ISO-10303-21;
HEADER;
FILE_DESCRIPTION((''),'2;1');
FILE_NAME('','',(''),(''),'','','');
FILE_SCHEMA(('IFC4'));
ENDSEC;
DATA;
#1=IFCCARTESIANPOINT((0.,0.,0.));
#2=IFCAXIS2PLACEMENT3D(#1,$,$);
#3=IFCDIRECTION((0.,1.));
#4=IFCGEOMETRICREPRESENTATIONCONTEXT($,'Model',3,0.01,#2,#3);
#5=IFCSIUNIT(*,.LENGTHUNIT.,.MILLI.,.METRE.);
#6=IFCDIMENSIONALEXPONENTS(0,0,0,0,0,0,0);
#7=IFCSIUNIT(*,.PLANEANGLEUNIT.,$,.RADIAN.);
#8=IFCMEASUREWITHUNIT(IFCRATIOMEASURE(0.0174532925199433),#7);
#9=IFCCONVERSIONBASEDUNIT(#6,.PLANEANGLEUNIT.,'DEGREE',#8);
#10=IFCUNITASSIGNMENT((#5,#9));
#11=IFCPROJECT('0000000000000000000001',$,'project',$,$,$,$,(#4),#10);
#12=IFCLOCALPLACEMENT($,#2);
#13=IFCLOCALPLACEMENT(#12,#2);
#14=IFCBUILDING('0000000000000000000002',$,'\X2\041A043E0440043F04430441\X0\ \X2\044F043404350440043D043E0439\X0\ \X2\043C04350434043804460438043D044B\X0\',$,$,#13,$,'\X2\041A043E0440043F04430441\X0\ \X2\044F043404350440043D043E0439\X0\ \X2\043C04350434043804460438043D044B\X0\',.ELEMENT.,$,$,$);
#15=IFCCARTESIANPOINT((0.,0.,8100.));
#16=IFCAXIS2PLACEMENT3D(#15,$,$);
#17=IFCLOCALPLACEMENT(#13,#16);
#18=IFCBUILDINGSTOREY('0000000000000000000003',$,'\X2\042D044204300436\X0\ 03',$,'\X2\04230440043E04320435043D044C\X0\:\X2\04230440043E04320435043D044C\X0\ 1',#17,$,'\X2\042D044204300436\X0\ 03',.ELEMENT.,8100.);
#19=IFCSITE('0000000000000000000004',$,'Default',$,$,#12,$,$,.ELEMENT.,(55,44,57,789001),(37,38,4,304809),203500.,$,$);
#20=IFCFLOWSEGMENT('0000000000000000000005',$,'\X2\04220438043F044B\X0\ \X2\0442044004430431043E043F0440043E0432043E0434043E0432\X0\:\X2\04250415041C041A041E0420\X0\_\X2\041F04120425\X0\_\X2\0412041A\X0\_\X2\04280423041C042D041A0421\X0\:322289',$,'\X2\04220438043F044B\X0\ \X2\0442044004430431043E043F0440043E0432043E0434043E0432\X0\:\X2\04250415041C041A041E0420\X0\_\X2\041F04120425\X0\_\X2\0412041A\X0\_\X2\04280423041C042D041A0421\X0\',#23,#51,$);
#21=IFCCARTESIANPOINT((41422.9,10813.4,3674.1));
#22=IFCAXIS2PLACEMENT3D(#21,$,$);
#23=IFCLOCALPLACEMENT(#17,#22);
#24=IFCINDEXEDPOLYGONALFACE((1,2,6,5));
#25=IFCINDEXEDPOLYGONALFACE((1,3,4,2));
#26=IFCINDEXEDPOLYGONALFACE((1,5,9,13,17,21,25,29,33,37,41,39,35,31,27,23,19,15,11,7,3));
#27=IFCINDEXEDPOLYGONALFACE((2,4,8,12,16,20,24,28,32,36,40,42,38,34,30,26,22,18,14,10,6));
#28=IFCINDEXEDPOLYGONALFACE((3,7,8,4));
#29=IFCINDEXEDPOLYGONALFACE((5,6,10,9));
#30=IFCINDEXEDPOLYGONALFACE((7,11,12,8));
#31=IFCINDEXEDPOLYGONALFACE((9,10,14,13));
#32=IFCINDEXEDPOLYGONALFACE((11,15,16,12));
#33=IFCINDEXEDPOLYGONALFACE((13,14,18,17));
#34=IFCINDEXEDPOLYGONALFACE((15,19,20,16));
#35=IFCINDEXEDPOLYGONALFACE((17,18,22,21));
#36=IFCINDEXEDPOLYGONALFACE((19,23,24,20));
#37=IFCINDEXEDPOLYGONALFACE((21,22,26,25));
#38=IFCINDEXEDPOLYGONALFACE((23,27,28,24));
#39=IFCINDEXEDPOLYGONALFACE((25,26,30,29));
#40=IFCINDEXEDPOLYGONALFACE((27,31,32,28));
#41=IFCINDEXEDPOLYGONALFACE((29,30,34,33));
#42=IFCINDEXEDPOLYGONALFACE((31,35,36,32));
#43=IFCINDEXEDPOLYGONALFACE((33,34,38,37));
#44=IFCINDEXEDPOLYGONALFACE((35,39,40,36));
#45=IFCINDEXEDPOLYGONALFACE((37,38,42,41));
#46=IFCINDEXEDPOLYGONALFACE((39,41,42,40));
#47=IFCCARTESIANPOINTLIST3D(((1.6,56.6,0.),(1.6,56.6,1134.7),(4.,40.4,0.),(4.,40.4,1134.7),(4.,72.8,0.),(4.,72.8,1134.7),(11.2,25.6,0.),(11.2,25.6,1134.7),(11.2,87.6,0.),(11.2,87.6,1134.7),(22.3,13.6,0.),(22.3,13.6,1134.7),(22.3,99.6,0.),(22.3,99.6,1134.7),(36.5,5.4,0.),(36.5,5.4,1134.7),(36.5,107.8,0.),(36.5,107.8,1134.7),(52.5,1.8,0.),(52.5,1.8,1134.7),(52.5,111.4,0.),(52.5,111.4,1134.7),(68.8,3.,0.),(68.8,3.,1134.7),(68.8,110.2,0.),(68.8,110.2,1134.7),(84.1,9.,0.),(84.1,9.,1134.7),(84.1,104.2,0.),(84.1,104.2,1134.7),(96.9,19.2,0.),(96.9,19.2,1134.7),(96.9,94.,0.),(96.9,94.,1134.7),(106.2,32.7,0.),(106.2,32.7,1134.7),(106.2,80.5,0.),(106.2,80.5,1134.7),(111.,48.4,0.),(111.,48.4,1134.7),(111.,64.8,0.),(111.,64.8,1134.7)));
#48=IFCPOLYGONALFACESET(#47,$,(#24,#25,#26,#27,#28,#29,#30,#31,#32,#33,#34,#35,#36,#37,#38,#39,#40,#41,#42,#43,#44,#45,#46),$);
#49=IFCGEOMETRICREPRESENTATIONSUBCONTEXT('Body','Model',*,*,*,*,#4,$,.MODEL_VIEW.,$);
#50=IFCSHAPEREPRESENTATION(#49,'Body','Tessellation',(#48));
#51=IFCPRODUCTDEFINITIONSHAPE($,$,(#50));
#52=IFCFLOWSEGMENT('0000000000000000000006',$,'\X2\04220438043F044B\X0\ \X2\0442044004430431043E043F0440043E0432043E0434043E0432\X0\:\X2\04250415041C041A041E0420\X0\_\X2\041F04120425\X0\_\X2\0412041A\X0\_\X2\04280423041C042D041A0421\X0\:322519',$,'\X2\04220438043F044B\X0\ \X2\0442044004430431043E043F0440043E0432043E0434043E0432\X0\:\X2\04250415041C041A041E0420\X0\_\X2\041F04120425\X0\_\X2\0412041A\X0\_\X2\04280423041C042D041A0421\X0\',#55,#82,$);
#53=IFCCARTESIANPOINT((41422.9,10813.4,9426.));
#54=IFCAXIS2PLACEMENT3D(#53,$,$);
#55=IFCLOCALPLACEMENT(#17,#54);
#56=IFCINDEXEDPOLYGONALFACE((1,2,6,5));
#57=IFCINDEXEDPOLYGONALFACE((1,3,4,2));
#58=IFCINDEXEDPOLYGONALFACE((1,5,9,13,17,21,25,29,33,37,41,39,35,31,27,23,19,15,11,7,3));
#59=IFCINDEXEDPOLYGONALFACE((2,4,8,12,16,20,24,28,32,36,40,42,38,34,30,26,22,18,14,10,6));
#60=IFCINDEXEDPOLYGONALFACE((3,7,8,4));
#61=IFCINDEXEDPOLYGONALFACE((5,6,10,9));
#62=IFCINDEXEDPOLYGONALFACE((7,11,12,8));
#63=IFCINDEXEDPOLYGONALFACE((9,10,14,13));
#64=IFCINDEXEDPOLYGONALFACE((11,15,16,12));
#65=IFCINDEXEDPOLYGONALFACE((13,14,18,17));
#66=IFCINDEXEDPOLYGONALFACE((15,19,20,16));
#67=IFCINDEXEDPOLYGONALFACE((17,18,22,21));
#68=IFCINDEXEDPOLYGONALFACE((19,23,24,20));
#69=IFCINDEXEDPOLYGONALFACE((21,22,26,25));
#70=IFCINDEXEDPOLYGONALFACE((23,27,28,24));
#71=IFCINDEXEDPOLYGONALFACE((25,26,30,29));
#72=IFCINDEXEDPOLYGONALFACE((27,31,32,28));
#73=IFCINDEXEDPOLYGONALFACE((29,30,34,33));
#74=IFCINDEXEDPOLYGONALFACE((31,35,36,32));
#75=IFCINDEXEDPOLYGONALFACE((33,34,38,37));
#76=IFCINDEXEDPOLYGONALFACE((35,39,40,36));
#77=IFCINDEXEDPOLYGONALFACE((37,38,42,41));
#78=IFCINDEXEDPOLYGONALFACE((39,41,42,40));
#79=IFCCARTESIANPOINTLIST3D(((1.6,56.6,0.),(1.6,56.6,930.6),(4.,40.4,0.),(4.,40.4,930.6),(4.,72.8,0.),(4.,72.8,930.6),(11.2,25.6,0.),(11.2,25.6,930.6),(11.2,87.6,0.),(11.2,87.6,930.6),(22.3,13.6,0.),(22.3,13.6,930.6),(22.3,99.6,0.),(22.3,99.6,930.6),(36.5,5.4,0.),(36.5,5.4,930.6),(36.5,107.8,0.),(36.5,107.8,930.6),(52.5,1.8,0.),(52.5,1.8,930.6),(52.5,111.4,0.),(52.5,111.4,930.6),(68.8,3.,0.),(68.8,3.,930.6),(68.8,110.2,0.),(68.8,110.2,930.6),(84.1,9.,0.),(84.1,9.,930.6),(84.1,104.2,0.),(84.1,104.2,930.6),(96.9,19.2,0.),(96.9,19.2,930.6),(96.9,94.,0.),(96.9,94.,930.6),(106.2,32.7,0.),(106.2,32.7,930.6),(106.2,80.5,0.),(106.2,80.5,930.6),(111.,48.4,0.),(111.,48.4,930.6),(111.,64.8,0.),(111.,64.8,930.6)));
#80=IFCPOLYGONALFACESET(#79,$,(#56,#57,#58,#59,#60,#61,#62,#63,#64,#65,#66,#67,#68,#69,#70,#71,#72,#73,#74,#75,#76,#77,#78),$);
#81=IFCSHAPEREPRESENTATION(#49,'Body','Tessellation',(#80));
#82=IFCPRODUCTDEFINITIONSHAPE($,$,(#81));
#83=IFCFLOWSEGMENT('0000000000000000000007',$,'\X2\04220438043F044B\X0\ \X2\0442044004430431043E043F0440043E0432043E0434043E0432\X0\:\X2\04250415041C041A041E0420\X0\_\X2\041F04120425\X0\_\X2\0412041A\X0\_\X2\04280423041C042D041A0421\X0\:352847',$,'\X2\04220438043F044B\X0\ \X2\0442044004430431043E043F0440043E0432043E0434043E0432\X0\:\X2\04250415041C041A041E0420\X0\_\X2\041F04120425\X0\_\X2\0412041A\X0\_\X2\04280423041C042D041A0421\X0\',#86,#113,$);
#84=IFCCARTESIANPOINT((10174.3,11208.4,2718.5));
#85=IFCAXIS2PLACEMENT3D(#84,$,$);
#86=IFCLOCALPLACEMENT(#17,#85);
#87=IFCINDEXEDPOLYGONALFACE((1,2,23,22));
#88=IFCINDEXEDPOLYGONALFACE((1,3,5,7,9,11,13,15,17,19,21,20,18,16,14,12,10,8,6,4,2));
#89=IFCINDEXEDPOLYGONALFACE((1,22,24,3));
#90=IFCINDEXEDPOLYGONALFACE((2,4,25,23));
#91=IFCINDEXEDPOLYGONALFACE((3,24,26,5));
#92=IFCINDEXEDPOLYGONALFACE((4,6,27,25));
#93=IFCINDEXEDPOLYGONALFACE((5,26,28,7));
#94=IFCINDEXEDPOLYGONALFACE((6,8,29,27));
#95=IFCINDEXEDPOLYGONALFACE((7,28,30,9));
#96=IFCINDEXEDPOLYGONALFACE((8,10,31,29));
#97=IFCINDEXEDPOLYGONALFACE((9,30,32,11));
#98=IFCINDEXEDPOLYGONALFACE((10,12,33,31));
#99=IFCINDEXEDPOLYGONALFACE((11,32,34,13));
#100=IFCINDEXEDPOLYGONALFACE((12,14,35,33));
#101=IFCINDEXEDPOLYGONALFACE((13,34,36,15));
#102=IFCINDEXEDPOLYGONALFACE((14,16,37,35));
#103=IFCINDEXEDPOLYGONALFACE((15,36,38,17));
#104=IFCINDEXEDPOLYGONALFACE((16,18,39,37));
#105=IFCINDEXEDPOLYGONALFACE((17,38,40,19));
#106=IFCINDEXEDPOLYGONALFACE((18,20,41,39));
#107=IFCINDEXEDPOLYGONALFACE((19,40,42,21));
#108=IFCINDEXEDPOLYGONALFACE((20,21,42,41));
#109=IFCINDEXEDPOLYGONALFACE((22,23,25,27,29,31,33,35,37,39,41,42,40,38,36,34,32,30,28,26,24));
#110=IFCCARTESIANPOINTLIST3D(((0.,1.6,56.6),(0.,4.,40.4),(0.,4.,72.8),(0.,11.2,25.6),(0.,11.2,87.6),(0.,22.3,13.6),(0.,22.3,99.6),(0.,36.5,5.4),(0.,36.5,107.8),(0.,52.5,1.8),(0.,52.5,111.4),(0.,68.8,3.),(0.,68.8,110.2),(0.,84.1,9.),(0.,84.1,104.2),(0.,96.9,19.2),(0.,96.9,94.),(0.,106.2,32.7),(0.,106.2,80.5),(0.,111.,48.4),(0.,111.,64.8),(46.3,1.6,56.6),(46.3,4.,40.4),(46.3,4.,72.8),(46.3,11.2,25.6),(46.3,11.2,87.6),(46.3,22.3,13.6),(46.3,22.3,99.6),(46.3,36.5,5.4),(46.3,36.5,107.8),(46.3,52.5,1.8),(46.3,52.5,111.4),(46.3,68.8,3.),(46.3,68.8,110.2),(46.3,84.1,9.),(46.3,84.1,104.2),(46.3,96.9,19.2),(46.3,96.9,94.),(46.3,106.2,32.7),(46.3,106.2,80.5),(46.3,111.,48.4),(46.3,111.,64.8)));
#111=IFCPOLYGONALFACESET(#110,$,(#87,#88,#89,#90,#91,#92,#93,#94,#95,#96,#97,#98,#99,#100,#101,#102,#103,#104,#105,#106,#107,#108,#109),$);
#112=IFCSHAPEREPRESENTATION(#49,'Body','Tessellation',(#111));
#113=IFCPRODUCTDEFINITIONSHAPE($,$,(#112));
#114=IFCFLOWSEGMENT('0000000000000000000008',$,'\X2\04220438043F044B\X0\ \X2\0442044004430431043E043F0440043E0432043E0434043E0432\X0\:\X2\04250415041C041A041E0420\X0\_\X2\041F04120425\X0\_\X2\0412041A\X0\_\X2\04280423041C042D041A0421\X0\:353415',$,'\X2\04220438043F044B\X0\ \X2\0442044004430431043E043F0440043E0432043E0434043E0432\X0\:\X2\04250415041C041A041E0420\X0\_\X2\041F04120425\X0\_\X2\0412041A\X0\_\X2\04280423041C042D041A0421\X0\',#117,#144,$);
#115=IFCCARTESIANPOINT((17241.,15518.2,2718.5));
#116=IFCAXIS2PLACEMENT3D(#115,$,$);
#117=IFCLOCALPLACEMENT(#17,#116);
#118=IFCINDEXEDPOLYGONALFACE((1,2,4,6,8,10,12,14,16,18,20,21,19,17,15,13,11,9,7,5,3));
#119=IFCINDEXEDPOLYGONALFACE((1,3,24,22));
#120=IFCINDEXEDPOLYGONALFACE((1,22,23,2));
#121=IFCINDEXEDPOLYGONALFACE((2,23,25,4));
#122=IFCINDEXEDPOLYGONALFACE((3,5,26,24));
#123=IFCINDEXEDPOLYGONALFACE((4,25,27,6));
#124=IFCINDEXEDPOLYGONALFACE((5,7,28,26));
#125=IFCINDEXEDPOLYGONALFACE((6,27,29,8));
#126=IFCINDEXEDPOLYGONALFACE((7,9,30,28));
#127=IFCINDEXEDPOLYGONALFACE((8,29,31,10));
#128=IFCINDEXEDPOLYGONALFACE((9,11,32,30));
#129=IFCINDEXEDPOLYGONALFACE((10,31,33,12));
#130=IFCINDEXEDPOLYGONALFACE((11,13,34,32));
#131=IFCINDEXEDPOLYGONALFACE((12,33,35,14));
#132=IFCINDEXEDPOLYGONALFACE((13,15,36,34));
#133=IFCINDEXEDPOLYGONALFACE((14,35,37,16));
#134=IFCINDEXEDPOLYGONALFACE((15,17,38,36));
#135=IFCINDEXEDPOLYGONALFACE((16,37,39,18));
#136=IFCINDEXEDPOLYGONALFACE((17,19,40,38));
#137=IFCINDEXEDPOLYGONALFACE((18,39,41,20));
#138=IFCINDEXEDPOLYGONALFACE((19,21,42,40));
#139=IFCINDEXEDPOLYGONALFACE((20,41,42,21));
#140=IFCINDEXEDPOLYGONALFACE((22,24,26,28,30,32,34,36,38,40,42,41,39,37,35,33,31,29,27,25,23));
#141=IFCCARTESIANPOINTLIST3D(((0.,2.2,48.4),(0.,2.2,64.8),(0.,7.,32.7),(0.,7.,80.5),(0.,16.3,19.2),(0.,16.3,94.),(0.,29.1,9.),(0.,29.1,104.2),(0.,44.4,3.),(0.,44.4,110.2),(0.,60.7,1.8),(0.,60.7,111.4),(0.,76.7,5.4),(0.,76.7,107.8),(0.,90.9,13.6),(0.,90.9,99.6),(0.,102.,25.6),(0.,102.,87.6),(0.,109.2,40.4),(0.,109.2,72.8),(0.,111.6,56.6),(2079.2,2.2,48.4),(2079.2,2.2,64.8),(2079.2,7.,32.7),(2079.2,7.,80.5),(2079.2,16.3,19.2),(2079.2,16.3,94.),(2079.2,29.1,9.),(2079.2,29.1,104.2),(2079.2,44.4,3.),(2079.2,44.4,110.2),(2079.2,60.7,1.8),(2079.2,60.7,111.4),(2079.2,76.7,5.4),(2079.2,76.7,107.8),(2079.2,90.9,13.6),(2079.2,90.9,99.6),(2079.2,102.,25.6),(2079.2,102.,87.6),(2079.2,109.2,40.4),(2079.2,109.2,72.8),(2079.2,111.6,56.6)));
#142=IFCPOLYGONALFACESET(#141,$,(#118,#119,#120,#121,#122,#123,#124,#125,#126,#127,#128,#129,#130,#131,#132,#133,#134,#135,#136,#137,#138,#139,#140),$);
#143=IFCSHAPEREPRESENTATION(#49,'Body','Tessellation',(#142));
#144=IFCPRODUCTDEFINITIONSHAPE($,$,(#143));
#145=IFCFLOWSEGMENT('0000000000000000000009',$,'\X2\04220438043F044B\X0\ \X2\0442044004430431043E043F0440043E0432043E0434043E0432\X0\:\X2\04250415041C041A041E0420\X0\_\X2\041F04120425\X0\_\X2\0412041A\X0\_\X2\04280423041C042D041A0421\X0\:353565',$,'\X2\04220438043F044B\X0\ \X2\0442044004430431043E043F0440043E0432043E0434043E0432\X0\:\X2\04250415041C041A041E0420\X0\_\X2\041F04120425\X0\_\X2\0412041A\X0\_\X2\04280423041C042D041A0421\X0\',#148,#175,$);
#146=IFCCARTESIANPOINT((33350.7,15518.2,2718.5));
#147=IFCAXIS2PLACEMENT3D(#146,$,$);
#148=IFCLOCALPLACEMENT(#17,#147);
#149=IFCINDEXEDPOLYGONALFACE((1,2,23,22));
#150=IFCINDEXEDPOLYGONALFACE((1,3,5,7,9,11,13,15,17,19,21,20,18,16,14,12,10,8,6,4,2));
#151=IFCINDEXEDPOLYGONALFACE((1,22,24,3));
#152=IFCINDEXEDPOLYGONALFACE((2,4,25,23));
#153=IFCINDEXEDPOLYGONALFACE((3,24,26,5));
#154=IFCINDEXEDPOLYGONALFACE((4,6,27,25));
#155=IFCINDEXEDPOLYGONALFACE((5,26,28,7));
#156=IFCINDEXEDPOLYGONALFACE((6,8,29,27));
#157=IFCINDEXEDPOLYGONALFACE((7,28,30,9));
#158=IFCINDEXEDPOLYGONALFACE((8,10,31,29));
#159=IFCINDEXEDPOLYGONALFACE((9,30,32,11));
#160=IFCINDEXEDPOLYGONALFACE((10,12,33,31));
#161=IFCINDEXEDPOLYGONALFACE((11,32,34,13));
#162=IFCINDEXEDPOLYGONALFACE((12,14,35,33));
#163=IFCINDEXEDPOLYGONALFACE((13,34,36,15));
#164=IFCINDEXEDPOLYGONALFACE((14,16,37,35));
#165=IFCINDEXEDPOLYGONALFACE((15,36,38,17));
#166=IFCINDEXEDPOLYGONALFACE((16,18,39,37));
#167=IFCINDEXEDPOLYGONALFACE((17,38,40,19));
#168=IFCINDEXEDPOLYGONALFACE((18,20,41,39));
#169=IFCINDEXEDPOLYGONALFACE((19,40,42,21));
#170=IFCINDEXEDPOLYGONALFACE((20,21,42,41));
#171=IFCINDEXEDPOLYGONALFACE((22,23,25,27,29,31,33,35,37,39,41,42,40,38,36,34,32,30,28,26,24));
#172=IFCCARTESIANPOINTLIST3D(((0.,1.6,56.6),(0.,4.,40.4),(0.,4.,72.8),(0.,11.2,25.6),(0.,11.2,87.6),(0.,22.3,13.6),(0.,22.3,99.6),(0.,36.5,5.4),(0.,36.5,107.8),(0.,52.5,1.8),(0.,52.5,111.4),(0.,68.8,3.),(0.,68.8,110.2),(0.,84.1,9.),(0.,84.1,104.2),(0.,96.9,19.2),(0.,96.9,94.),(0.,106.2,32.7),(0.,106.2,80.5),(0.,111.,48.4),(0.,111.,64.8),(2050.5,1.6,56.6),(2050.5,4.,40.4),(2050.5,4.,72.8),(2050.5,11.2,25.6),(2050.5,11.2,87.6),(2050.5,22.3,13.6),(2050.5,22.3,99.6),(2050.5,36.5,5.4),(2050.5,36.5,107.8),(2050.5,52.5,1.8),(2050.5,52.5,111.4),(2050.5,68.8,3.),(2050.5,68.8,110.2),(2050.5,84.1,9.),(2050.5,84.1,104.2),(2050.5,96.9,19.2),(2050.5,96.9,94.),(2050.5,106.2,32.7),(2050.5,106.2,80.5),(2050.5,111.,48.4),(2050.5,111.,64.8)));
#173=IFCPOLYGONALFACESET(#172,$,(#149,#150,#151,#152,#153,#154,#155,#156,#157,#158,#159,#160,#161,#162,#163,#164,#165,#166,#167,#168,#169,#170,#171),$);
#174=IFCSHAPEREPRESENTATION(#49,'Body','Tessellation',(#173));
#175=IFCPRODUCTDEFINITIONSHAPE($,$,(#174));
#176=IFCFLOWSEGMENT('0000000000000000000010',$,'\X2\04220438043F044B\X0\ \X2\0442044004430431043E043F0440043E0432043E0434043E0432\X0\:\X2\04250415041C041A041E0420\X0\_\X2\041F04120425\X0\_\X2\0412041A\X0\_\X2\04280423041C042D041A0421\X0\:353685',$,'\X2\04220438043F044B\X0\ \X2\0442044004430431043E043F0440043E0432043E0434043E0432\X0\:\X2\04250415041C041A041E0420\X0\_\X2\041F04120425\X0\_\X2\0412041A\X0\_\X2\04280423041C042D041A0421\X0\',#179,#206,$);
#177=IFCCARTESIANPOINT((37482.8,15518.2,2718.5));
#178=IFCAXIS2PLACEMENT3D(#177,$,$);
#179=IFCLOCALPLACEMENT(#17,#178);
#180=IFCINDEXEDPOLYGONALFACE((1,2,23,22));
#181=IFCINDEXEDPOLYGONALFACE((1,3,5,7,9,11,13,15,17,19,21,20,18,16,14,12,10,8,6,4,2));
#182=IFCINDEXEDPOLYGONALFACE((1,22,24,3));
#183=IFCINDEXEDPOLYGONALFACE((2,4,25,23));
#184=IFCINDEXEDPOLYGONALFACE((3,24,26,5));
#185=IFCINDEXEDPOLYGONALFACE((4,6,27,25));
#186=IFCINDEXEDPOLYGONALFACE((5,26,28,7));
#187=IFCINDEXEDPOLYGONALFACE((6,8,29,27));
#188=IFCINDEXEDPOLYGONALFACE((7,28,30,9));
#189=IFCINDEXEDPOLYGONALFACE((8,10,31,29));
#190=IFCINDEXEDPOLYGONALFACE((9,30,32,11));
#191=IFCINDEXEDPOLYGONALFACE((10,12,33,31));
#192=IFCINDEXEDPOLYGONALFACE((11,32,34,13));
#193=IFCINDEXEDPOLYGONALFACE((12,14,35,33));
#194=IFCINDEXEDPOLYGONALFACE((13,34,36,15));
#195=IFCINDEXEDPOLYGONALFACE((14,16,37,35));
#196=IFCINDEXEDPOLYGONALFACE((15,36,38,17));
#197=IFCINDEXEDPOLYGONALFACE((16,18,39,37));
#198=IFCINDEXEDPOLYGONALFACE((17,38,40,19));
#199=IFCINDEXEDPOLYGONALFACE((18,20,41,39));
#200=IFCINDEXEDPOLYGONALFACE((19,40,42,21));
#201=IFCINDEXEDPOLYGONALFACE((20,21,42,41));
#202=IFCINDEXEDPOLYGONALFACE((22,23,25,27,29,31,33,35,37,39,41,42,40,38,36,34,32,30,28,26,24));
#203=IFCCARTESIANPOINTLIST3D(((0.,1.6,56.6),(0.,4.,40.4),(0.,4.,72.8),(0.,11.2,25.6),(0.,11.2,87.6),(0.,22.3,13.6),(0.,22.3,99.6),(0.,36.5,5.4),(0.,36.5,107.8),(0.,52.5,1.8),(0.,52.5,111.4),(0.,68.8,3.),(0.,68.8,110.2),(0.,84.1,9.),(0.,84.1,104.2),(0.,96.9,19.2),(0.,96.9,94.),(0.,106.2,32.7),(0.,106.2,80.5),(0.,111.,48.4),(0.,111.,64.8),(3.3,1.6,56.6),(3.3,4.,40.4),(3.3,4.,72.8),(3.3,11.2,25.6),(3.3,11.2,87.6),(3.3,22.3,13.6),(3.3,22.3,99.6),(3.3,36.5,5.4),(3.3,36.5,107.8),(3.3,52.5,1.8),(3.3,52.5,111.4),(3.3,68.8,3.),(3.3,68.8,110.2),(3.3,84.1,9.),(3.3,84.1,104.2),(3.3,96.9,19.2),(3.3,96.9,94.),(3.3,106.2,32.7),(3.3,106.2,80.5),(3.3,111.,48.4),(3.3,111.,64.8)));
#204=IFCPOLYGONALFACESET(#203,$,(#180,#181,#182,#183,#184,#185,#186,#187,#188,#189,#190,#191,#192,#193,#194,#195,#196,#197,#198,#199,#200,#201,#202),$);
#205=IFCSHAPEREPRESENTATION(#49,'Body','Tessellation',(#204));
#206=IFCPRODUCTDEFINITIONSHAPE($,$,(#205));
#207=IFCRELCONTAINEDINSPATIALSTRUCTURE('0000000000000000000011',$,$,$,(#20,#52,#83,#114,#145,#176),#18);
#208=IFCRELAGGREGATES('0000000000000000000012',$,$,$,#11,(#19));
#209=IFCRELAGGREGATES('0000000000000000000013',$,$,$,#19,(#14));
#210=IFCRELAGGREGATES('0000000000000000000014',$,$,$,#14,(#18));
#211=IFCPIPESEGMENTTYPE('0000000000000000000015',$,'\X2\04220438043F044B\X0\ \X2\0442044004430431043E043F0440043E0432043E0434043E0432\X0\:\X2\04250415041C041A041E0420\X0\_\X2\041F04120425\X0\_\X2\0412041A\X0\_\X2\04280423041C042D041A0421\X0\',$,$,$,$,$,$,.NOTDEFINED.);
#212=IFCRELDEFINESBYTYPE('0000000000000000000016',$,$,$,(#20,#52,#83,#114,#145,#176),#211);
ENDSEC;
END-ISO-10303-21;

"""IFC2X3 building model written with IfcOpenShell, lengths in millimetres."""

from ifc_helpers import new_model, entity, si_unit, converted_unit, direction, frame, origin, origin_2d_with_axis, place, context, subcontext, project, spatial, circle, extrude, type_object, element, save


model = new_model("IFC2X3")

# Units and contexts
model_context = context("Model", 3, precision=0.01, world=origin(), true_north=direction((0.0, 1.0)))
body_context = subcontext(model_context, "Body", "Model", "MODEL_VIEW")
ifc_project = project(units=[si_unit("LENGTHUNIT", "METRE", prefix="MILLI"), converted_unit("PLANEANGLEUNIT", "DEGREE", entity("IfcRatioMeasure", 0.0174532925199433), si_unit("PLANEANGLEUNIT", "RADIAN"), dimensions=[0, 0, 0, 0, 0, 0, 0])], contexts=[model_context])

# Site, building, storey
site_placement = place(None, origin())
site = spatial("IfcSite", under=ifc_project, at=site_placement, Name="Default", CompositionType="ELEMENT", RefLatitude=(55, 44, 57, 789001), RefLongitude=(37, 38, 4, 304809), RefElevation=203500.0)
building_placement = place(site_placement, origin())
building = spatial("IfcBuilding", under=site, at=building_placement, Name="Корпус ядерной медицины", LongName="Корпус ядерной медицины", CompositionType="ELEMENT")
storey_placement = place(building_placement, frame((0.0, 0.0, 8100.0)))
storey = spatial("IfcBuildingStorey", under=building, at=storey_placement, Name="Этаж 03", ObjectType="Уровень:Уровень 1", LongName="Этаж 03", CompositionType="ELEMENT", Elevation=8100.0)

# Flow segments
pipe_segment_type = type_object("IfcPipeSegmentType", Name="Типы трубопроводов:ХЕМКОР_ПВХ_ВК_ШУМЭКС", PredefinedType="NOTDEFINED")
flow_segment_1_placement = place(storey_placement, frame((41422.9, 10813.4, 3674.1)))
element("IfcFlowSegment", 1, at=flow_segment_1_placement, inside=storey, type_object=pipe_segment_type, Name="Типы трубопроводов:ХЕМКОР_ПВХ_ВК_ШУМЭКС:322289", ObjectType="Типы трубопроводов:ХЕМКОР_ПВХ_ВК_ШУМЭКС", context=body_context, shape_type="SweptSolid", body=[
    extrude(circle(Radius=55.0, at=origin_2d_with_axis()), frame((56.6, 56.6, 0.0), z_axis=(0.0, 0.0, 1.0), x_axis=(-1.0, 0.0, 0.0)), (0.0, 0.0, 1.0), 1134.7),
])
flow_segment_2_placement = place(storey_placement, frame((41422.9, 10813.4, 9426.0)))
element("IfcFlowSegment", 2, at=flow_segment_2_placement, inside=storey, type_object=pipe_segment_type, Name="Типы трубопроводов:ХЕМКОР_ПВХ_ВК_ШУМЭКС:322519", ObjectType="Типы трубопроводов:ХЕМКОР_ПВХ_ВК_ШУМЭКС", context=body_context, shape_type="SweptSolid", body=[
    extrude(circle(Radius=55.0, at=origin_2d_with_axis()), frame((56.6, 56.6, 0.0), z_axis=(0.0, 0.0, 1.0), x_axis=(-1.0, 0.0, 0.0)), (0.0, 0.0, 1.0), 930.6),
])
flow_segment_3_placement = place(storey_placement, frame((10174.3, 11208.4, 2718.5)))
element("IfcFlowSegment", 3, at=flow_segment_3_placement, inside=storey, type_object=pipe_segment_type, Name="Типы трубопроводов:ХЕМКОР_ПВХ_ВК_ШУМЭКС:352847", ObjectType="Типы трубопроводов:ХЕМКОР_ПВХ_ВК_ШУМЭКС", context=body_context, shape_type="SweptSolid", body=[
    extrude(circle(Radius=55.0, at=origin_2d_with_axis()), frame((0.0, 56.6, 56.6), z_axis=(1.0, 0.0, 0.0), x_axis=(0.0, -1.0, 0.0)), (0.0, 0.0, 1.0), 46.3),
])
flow_segment_4_placement = place(storey_placement, frame((17241.0, 15518.2, 2718.5)))
element("IfcFlowSegment", 4, at=flow_segment_4_placement, inside=storey, type_object=pipe_segment_type, Name="Типы трубопроводов:ХЕМКОР_ПВХ_ВК_ШУМЭКС:353415", ObjectType="Типы трубопроводов:ХЕМКОР_ПВХ_ВК_ШУМЭКС", context=body_context, shape_type="SweptSolid", body=[
    extrude(circle(Radius=55.0, at=origin_2d_with_axis()), frame((0.0, 56.6, 56.6), z_axis=(1.0, 0.0, 0.0), x_axis=(0.0, 1.0, 0.0)), (0.0, 0.0, 1.0), 2079.2),
])
flow_segment_5_placement = place(storey_placement, frame((33350.7, 15518.2, 2718.5)))
element("IfcFlowSegment", 5, at=flow_segment_5_placement, inside=storey, type_object=pipe_segment_type, Name="Типы трубопроводов:ХЕМКОР_ПВХ_ВК_ШУМЭКС:353565", ObjectType="Типы трубопроводов:ХЕМКОР_ПВХ_ВК_ШУМЭКС", context=body_context, shape_type="SweptSolid", body=[
    extrude(circle(Radius=55.0, at=origin_2d_with_axis()), frame((0.0, 56.6, 56.6), z_axis=(1.0, 0.0, 0.0), x_axis=(0.0, -1.0, 0.0)), (0.0, 0.0, 1.0), 2050.5),
])
flow_segment_6_placement = place(storey_placement, frame((37482.8, 15518.2, 2718.5)))
element("IfcFlowSegment", 6, at=flow_segment_6_placement, inside=storey, type_object=pipe_segment_type, Name="Типы трубопроводов:ХЕМКОР_ПВХ_ВК_ШУМЭКС:353685", ObjectType="Типы трубопроводов:ХЕМКОР_ПВХ_ВК_ШУМЭКС", context=body_context, shape_type="SweptSolid", body=[
    extrude(circle(Radius=55.0, at=origin_2d_with_axis()), frame((0.0, 56.6, 56.6), z_axis=(1.0, 0.0, 0.0), x_axis=(0.0, -1.0, 0.0)), (0.0, 0.0, 1.0), 3.3),
])

save(model, "model.ifc")
